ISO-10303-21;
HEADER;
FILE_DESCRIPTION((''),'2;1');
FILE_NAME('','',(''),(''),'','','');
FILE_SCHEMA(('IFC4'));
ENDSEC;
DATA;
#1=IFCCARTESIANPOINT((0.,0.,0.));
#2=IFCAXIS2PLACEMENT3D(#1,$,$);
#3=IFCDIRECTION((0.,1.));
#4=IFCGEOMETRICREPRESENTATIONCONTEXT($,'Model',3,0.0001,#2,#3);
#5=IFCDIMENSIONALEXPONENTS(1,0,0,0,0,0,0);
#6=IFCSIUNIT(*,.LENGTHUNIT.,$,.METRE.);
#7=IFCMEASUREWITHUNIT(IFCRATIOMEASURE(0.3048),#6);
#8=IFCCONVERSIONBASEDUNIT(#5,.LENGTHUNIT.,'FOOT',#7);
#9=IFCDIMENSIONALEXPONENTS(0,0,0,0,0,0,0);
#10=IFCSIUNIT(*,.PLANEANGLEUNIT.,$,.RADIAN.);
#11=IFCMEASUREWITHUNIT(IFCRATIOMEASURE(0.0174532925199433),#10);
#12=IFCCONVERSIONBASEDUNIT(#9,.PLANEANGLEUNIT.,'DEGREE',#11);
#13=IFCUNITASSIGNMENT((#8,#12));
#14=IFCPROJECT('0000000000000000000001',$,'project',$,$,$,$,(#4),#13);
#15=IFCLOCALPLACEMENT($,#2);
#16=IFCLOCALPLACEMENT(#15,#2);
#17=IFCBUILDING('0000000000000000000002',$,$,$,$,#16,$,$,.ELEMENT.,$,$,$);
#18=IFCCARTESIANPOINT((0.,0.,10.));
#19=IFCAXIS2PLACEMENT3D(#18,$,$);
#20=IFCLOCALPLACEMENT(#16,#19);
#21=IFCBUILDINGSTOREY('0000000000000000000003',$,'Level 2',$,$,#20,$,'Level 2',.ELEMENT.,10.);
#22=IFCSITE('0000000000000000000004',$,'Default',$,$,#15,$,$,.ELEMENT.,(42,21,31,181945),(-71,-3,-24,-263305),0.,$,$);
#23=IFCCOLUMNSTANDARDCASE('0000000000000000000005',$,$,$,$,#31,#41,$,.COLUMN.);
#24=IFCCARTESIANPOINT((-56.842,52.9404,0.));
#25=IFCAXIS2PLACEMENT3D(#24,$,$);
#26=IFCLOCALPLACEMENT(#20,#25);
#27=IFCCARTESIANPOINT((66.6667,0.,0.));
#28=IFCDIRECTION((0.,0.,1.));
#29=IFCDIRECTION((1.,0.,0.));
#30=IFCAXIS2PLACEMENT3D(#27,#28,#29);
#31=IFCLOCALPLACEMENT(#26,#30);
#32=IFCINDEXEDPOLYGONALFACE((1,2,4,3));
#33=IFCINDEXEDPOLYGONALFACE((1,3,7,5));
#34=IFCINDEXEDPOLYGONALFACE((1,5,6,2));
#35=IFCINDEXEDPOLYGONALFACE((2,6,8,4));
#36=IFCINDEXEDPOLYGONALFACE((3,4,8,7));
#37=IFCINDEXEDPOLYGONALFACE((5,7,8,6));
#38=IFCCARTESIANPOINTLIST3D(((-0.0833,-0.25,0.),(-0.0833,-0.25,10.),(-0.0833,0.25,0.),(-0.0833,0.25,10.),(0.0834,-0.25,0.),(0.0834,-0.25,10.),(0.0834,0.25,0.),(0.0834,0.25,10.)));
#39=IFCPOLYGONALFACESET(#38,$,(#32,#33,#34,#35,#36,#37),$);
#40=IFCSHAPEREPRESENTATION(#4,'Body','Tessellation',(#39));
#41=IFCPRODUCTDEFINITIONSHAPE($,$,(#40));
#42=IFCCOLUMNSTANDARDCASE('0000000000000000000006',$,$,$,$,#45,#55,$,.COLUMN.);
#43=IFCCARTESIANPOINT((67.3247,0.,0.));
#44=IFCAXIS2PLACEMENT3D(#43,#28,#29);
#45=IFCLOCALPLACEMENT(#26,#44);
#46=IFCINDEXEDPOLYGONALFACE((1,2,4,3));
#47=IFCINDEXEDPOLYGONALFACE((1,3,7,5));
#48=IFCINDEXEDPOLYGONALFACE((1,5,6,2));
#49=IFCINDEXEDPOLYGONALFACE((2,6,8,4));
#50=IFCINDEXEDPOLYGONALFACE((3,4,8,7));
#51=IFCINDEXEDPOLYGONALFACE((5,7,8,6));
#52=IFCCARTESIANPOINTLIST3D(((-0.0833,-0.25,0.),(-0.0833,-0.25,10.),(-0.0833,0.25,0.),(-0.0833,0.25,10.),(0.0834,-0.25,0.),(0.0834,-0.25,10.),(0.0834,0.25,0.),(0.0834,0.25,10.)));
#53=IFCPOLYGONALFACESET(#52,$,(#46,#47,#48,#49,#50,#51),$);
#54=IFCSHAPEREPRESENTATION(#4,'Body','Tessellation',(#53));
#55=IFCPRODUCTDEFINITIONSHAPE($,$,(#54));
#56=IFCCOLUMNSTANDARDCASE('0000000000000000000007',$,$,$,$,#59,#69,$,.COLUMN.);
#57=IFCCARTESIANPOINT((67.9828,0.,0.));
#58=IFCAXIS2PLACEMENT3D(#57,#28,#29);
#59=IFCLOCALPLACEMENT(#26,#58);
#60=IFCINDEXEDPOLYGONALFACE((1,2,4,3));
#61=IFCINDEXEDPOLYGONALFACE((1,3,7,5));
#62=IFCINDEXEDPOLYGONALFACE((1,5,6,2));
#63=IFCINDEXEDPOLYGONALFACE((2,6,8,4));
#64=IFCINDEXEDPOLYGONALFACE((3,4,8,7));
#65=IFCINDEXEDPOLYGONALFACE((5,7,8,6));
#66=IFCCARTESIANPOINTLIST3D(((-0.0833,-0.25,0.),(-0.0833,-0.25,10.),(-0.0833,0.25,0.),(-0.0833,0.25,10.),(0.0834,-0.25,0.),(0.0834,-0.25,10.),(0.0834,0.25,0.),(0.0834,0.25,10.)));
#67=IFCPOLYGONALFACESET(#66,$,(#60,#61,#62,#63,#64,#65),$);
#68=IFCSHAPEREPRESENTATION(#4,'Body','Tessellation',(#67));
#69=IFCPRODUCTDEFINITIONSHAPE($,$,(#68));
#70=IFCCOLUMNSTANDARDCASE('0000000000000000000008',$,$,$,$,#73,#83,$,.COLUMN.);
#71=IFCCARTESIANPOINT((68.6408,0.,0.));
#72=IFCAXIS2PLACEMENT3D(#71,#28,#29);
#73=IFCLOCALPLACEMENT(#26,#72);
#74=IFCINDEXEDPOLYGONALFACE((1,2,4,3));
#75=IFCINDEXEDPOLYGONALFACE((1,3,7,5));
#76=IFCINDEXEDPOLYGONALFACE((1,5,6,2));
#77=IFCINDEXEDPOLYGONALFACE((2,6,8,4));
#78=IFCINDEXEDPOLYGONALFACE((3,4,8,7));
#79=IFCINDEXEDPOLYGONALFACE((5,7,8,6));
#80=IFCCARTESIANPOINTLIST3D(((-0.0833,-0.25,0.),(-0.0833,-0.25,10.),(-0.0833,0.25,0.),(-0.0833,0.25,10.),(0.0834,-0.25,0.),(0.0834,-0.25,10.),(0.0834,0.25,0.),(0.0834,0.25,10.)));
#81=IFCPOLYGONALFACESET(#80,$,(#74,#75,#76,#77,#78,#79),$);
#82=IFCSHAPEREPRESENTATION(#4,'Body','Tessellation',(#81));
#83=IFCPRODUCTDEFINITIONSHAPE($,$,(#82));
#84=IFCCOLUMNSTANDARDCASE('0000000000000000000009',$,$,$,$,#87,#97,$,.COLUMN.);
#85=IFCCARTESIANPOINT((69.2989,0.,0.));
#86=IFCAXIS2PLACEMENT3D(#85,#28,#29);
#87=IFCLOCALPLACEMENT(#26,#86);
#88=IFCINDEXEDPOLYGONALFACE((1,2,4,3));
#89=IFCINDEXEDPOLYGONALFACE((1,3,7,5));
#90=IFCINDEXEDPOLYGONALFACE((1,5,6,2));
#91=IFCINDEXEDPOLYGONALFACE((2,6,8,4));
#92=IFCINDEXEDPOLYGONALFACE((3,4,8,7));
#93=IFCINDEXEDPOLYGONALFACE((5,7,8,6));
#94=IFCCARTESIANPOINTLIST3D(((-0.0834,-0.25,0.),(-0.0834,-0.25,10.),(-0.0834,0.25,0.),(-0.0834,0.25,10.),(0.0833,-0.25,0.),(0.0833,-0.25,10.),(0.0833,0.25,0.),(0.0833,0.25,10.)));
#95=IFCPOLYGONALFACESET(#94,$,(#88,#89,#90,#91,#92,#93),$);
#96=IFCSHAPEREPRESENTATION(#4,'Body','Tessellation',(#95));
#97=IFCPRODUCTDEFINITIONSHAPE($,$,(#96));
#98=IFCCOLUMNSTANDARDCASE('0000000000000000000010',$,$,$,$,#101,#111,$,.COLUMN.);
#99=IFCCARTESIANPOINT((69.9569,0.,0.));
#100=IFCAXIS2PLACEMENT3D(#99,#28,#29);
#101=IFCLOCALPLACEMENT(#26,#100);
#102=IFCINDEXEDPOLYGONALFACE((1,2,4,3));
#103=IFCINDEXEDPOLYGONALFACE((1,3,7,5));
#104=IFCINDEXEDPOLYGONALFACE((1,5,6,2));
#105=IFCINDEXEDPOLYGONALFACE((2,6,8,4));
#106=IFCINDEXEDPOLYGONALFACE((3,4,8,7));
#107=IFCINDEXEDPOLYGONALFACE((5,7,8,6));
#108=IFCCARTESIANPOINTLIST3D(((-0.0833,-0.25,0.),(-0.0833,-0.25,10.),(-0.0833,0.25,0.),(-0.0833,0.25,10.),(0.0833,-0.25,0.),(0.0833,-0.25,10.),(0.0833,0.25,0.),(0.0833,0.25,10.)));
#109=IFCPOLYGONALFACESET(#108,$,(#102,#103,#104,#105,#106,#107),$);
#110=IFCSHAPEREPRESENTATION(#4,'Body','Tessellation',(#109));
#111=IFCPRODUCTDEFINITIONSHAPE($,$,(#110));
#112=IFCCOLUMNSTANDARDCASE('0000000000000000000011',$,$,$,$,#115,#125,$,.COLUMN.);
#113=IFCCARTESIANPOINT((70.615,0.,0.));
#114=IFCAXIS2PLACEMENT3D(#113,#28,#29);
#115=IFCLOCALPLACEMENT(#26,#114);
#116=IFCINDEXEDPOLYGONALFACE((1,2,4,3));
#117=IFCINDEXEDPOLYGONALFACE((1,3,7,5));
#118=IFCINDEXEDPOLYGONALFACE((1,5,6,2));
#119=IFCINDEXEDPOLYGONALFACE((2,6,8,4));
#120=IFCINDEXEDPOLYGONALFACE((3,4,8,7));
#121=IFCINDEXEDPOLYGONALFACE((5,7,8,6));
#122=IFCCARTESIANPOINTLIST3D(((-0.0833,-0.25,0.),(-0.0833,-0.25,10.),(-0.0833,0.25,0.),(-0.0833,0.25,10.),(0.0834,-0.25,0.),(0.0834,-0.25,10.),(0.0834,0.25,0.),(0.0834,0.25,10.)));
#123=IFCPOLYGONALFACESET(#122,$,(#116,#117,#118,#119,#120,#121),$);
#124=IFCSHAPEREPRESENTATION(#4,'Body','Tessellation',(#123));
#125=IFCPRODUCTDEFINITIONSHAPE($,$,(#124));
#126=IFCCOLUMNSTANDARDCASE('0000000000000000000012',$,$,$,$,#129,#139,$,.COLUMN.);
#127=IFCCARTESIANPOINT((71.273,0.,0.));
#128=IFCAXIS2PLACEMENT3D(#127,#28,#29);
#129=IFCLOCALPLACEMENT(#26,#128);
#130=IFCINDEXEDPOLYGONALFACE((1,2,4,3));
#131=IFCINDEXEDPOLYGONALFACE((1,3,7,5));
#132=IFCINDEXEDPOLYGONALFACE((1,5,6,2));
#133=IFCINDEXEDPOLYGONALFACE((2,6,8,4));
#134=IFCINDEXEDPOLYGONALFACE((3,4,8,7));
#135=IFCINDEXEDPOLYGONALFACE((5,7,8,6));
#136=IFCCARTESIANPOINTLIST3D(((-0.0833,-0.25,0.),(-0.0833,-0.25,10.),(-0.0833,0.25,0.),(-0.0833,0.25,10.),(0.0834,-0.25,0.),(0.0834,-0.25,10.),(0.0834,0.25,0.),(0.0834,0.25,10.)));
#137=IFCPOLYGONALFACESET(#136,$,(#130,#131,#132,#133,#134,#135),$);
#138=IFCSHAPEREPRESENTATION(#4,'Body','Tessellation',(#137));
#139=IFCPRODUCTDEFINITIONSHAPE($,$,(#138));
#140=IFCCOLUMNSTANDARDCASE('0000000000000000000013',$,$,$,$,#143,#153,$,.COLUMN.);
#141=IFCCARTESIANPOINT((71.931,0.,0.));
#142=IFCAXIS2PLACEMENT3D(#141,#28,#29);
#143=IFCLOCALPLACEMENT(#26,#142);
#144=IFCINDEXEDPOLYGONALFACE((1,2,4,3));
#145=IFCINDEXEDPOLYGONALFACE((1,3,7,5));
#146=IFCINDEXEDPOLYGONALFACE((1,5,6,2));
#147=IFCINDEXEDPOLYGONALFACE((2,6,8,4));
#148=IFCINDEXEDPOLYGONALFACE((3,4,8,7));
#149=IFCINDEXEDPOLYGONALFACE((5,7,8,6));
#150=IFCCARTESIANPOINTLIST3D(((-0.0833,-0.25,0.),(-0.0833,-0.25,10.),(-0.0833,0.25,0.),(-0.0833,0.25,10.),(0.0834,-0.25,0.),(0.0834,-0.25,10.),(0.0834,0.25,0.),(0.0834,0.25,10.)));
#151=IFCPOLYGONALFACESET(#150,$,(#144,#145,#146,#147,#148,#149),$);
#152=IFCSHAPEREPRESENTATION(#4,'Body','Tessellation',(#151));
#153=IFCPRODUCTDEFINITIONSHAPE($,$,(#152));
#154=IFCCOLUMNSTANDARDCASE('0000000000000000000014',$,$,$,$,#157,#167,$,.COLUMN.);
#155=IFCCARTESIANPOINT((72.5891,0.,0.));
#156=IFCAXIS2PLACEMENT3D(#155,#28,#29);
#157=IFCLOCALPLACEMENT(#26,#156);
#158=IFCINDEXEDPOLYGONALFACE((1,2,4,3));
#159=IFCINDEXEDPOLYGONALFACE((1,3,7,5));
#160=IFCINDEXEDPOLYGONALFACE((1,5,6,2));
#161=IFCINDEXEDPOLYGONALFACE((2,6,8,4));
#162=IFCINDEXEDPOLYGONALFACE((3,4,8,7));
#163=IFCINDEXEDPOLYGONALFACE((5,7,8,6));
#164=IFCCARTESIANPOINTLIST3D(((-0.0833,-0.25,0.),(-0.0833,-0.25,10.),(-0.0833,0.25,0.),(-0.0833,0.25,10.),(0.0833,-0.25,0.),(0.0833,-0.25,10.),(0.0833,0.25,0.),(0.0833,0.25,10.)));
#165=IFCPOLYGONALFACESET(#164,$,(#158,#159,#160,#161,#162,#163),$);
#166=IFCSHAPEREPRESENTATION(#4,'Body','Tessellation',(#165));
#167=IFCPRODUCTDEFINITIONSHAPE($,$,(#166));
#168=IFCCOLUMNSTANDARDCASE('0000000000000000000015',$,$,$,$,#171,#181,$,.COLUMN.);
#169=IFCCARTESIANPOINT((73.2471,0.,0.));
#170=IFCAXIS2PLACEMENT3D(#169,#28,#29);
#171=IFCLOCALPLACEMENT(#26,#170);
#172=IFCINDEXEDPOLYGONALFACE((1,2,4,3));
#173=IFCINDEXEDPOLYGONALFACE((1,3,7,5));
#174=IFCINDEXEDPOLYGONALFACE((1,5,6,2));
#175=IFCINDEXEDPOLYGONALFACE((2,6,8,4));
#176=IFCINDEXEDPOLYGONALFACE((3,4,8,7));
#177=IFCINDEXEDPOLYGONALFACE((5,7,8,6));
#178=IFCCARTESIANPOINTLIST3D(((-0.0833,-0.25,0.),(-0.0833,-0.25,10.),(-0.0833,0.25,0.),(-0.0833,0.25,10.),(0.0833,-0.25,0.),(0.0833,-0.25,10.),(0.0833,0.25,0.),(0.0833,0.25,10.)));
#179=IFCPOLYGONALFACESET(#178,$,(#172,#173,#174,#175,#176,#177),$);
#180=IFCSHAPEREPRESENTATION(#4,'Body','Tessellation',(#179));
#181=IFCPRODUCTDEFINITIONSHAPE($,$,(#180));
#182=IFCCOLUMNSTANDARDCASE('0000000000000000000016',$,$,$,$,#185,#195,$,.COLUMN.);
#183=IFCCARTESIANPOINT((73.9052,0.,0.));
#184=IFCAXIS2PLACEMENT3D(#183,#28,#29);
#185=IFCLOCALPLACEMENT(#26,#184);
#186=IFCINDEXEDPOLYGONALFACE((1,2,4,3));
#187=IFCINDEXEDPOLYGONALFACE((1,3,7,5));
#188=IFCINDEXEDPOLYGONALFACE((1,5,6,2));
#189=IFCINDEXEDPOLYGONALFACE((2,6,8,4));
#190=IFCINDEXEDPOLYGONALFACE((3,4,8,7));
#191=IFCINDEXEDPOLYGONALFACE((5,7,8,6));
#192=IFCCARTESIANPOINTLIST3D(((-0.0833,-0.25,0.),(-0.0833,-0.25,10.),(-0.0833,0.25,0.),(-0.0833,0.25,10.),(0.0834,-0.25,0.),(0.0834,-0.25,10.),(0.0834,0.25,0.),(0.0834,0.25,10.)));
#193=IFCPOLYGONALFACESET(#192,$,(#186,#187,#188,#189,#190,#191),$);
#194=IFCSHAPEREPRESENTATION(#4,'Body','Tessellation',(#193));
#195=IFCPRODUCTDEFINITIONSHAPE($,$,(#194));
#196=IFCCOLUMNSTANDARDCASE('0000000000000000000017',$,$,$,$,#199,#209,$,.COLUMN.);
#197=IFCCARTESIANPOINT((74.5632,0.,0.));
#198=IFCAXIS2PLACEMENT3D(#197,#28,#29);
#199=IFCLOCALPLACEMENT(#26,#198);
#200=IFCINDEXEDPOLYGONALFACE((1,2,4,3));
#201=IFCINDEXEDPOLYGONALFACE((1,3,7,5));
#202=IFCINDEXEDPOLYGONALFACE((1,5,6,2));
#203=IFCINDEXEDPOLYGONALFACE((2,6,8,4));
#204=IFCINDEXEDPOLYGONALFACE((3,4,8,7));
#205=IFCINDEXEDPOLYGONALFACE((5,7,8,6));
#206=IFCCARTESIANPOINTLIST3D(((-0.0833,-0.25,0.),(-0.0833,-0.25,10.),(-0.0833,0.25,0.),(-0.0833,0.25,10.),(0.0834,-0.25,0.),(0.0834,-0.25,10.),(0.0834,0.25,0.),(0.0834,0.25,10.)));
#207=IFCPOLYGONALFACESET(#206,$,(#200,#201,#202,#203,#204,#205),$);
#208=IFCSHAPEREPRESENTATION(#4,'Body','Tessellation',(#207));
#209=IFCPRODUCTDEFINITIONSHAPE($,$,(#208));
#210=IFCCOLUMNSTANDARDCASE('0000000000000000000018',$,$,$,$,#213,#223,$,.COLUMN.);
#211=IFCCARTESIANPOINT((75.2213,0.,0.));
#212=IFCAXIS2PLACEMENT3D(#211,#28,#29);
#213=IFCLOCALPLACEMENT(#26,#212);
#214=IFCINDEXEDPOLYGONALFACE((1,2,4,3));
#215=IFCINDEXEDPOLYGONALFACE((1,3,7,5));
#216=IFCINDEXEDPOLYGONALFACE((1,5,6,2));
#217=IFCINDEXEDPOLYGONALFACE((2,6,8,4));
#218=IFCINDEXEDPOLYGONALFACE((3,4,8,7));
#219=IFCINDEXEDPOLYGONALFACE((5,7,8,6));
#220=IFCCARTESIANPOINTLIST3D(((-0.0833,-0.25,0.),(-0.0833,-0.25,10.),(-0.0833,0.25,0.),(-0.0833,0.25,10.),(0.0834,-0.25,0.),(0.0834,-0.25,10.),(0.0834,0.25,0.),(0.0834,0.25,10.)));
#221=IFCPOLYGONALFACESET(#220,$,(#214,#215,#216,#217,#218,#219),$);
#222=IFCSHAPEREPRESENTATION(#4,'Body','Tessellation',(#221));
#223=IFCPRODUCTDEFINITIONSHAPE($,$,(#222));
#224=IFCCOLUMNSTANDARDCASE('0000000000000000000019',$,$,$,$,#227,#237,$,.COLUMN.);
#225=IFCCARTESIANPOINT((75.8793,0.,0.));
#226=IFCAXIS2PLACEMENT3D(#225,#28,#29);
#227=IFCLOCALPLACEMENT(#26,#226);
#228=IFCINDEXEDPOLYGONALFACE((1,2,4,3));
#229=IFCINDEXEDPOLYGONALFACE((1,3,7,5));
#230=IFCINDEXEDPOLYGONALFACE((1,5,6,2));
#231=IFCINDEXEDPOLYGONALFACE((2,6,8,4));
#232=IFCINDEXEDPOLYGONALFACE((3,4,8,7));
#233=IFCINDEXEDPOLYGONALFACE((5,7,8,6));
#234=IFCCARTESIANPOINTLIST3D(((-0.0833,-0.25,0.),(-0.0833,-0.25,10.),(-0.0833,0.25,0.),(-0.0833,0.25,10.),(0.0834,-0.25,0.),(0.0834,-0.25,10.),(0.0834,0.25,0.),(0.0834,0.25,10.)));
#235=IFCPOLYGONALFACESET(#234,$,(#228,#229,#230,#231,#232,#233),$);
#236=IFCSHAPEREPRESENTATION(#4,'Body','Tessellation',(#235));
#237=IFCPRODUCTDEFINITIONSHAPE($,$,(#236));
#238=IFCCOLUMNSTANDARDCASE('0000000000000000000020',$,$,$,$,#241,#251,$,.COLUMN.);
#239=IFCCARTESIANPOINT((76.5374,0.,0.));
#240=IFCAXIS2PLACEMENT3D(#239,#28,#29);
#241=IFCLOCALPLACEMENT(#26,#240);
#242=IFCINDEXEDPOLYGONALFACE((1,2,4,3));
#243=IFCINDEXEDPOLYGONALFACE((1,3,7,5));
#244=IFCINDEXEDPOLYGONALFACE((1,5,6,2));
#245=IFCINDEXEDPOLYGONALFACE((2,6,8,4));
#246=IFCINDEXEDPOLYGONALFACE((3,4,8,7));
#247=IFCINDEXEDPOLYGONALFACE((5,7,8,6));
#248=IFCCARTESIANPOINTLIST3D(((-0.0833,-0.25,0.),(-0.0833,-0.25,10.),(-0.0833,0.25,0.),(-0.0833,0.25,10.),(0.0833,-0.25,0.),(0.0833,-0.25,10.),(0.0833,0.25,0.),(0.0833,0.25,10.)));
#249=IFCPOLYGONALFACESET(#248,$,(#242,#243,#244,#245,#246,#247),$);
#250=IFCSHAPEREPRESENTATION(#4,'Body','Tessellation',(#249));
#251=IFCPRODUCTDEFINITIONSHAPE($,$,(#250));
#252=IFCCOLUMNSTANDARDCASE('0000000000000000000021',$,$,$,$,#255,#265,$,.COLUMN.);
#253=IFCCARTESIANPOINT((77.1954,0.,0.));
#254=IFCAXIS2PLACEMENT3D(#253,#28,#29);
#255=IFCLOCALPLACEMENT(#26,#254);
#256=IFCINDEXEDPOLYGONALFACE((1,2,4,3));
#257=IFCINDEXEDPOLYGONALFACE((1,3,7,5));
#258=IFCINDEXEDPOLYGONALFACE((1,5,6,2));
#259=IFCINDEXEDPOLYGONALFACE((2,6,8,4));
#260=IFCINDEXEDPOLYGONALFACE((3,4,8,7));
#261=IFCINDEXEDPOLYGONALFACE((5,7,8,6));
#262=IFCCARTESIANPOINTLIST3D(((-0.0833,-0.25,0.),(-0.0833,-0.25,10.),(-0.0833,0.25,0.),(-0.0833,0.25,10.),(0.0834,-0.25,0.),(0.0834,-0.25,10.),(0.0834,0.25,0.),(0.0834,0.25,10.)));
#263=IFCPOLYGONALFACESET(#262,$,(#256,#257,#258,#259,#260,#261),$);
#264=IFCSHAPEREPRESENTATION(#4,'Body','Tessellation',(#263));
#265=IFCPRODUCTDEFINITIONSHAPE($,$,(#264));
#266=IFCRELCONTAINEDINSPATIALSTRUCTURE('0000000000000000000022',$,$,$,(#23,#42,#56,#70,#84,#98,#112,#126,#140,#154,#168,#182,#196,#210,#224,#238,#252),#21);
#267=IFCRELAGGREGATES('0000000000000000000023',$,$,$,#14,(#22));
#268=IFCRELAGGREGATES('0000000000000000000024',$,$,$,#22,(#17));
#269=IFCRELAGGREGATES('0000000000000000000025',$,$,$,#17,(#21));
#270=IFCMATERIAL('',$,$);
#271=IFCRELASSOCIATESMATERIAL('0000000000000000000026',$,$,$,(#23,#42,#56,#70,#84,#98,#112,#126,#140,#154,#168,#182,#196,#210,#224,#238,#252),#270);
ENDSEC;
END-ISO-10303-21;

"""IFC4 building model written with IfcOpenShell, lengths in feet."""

from ifc_helpers import new_model, entity, si_unit, converted_unit, direction, frame, origin, place, context, project, spatial, rectangle, extrude, material, element, save


model = new_model("IFC4")

# Units and contexts
model_context = context("Model", 3, precision=0.0001, world=origin(), true_north=direction((0.0, 1.0)))
ifc_project = project(units=[converted_unit("LENGTHUNIT", "FOOT", entity("IfcRatioMeasure", 0.3048), si_unit("LENGTHUNIT", "METRE"), dimensions=[1, 0, 0, 0, 0, 0, 0]), converted_unit("PLANEANGLEUNIT", "DEGREE", entity("IfcRatioMeasure", 0.0174532925199433), si_unit("PLANEANGLEUNIT", "RADIAN"), dimensions=[0, 0, 0, 0, 0, 0, 0])], contexts=[model_context])

# Site, building, storey
site_placement = place(None, origin())
site = spatial("IfcSite", under=ifc_project, at=site_placement, Name="Default", CompositionType="ELEMENT", RefLatitude=(42, 21, 31, 181945), RefLongitude=(-71, -3, -24, -263305), RefElevation=0.0)
building_placement = place(site_placement, origin())
building = spatial("IfcBuilding", under=site, at=building_placement, CompositionType="ELEMENT")
storey_placement = place(building_placement, frame((0.0, 0.0, 10.0)))
storey = spatial("IfcBuildingStorey", under=building, at=storey_placement, Name="Level 2", LongName="Level 2", CompositionType="ELEMENT", Elevation=10.0)

# Columns
ifc_material_1 = material(Name="")
placement = place(storey_placement, frame((-56.842, 52.9404, 0.0)))
for number, where, z_axis, x_axis in (
    (1, (66.6667, 0.0, 0.0), (0.0, 0.0, 1.0), (1.0, 0.0, 0.0)),
    (2, (67.3247, 0.0, 0.0), (0.0, 0.0, 1.0), (1.0, 0.0, 0.0)),
    (3, (67.9828, 0.0, 0.0), (0.0, 0.0, 1.0), (1.0, 0.0, 0.0)),
    (4, (68.6408, 0.0, 0.0), (0.0, 0.0, 1.0), (1.0, 0.0, 0.0)),
    (5, (69.2989, 0.0, 0.0), (0.0, 0.0, 1.0), (1.0, 0.0, 0.0)),
    (6, (69.9569, 0.0, 0.0), (0.0, 0.0, 1.0), (1.0, 0.0, 0.0)),
    (7, (70.615, 0.0, 0.0), (0.0, 0.0, 1.0), (1.0, 0.0, 0.0)),
    (8, (71.273, 0.0, 0.0), (0.0, 0.0, 1.0), (1.0, 0.0, 0.0)),
    (9, (71.931, 0.0, 0.0), (0.0, 0.0, 1.0), (1.0, 0.0, 0.0)),
    (10, (72.5891, 0.0, 0.0), (0.0, 0.0, 1.0), (1.0, 0.0, 0.0)),
    (11, (73.2471, 0.0, 0.0), (0.0, 0.0, 1.0), (1.0, 0.0, 0.0)),
    (12, (73.9052, 0.0, 0.0), (0.0, 0.0, 1.0), (1.0, 0.0, 0.0)),
    (13, (74.5632, 0.0, 0.0), (0.0, 0.0, 1.0), (1.0, 0.0, 0.0)),
    (14, (75.2213, 0.0, 0.0), (0.0, 0.0, 1.0), (1.0, 0.0, 0.0)),
    (15, (75.8793, 0.0, 0.0), (0.0, 0.0, 1.0), (1.0, 0.0, 0.0)),
    (16, (76.5374, 0.0, 0.0), (0.0, 0.0, 1.0), (1.0, 0.0, 0.0)),
    (17, (77.1954, 0.0, 0.0), (0.0, 0.0, 1.0), (1.0, 0.0, 0.0)),
):
    element("IfcColumnStandardCase", number, at=place(placement, frame(where, z_axis=z_axis, x_axis=x_axis)), inside=storey, material=ifc_material_1, PredefinedType="COLUMN", context=model_context, shape_type="SweptSolid", body=[
        extrude(rectangle(XDim=0.1667, YDim=0.5), origin(), (0.0, 0.0, 1.0), 10.0),
    ])

save(model, "model.ifc")
